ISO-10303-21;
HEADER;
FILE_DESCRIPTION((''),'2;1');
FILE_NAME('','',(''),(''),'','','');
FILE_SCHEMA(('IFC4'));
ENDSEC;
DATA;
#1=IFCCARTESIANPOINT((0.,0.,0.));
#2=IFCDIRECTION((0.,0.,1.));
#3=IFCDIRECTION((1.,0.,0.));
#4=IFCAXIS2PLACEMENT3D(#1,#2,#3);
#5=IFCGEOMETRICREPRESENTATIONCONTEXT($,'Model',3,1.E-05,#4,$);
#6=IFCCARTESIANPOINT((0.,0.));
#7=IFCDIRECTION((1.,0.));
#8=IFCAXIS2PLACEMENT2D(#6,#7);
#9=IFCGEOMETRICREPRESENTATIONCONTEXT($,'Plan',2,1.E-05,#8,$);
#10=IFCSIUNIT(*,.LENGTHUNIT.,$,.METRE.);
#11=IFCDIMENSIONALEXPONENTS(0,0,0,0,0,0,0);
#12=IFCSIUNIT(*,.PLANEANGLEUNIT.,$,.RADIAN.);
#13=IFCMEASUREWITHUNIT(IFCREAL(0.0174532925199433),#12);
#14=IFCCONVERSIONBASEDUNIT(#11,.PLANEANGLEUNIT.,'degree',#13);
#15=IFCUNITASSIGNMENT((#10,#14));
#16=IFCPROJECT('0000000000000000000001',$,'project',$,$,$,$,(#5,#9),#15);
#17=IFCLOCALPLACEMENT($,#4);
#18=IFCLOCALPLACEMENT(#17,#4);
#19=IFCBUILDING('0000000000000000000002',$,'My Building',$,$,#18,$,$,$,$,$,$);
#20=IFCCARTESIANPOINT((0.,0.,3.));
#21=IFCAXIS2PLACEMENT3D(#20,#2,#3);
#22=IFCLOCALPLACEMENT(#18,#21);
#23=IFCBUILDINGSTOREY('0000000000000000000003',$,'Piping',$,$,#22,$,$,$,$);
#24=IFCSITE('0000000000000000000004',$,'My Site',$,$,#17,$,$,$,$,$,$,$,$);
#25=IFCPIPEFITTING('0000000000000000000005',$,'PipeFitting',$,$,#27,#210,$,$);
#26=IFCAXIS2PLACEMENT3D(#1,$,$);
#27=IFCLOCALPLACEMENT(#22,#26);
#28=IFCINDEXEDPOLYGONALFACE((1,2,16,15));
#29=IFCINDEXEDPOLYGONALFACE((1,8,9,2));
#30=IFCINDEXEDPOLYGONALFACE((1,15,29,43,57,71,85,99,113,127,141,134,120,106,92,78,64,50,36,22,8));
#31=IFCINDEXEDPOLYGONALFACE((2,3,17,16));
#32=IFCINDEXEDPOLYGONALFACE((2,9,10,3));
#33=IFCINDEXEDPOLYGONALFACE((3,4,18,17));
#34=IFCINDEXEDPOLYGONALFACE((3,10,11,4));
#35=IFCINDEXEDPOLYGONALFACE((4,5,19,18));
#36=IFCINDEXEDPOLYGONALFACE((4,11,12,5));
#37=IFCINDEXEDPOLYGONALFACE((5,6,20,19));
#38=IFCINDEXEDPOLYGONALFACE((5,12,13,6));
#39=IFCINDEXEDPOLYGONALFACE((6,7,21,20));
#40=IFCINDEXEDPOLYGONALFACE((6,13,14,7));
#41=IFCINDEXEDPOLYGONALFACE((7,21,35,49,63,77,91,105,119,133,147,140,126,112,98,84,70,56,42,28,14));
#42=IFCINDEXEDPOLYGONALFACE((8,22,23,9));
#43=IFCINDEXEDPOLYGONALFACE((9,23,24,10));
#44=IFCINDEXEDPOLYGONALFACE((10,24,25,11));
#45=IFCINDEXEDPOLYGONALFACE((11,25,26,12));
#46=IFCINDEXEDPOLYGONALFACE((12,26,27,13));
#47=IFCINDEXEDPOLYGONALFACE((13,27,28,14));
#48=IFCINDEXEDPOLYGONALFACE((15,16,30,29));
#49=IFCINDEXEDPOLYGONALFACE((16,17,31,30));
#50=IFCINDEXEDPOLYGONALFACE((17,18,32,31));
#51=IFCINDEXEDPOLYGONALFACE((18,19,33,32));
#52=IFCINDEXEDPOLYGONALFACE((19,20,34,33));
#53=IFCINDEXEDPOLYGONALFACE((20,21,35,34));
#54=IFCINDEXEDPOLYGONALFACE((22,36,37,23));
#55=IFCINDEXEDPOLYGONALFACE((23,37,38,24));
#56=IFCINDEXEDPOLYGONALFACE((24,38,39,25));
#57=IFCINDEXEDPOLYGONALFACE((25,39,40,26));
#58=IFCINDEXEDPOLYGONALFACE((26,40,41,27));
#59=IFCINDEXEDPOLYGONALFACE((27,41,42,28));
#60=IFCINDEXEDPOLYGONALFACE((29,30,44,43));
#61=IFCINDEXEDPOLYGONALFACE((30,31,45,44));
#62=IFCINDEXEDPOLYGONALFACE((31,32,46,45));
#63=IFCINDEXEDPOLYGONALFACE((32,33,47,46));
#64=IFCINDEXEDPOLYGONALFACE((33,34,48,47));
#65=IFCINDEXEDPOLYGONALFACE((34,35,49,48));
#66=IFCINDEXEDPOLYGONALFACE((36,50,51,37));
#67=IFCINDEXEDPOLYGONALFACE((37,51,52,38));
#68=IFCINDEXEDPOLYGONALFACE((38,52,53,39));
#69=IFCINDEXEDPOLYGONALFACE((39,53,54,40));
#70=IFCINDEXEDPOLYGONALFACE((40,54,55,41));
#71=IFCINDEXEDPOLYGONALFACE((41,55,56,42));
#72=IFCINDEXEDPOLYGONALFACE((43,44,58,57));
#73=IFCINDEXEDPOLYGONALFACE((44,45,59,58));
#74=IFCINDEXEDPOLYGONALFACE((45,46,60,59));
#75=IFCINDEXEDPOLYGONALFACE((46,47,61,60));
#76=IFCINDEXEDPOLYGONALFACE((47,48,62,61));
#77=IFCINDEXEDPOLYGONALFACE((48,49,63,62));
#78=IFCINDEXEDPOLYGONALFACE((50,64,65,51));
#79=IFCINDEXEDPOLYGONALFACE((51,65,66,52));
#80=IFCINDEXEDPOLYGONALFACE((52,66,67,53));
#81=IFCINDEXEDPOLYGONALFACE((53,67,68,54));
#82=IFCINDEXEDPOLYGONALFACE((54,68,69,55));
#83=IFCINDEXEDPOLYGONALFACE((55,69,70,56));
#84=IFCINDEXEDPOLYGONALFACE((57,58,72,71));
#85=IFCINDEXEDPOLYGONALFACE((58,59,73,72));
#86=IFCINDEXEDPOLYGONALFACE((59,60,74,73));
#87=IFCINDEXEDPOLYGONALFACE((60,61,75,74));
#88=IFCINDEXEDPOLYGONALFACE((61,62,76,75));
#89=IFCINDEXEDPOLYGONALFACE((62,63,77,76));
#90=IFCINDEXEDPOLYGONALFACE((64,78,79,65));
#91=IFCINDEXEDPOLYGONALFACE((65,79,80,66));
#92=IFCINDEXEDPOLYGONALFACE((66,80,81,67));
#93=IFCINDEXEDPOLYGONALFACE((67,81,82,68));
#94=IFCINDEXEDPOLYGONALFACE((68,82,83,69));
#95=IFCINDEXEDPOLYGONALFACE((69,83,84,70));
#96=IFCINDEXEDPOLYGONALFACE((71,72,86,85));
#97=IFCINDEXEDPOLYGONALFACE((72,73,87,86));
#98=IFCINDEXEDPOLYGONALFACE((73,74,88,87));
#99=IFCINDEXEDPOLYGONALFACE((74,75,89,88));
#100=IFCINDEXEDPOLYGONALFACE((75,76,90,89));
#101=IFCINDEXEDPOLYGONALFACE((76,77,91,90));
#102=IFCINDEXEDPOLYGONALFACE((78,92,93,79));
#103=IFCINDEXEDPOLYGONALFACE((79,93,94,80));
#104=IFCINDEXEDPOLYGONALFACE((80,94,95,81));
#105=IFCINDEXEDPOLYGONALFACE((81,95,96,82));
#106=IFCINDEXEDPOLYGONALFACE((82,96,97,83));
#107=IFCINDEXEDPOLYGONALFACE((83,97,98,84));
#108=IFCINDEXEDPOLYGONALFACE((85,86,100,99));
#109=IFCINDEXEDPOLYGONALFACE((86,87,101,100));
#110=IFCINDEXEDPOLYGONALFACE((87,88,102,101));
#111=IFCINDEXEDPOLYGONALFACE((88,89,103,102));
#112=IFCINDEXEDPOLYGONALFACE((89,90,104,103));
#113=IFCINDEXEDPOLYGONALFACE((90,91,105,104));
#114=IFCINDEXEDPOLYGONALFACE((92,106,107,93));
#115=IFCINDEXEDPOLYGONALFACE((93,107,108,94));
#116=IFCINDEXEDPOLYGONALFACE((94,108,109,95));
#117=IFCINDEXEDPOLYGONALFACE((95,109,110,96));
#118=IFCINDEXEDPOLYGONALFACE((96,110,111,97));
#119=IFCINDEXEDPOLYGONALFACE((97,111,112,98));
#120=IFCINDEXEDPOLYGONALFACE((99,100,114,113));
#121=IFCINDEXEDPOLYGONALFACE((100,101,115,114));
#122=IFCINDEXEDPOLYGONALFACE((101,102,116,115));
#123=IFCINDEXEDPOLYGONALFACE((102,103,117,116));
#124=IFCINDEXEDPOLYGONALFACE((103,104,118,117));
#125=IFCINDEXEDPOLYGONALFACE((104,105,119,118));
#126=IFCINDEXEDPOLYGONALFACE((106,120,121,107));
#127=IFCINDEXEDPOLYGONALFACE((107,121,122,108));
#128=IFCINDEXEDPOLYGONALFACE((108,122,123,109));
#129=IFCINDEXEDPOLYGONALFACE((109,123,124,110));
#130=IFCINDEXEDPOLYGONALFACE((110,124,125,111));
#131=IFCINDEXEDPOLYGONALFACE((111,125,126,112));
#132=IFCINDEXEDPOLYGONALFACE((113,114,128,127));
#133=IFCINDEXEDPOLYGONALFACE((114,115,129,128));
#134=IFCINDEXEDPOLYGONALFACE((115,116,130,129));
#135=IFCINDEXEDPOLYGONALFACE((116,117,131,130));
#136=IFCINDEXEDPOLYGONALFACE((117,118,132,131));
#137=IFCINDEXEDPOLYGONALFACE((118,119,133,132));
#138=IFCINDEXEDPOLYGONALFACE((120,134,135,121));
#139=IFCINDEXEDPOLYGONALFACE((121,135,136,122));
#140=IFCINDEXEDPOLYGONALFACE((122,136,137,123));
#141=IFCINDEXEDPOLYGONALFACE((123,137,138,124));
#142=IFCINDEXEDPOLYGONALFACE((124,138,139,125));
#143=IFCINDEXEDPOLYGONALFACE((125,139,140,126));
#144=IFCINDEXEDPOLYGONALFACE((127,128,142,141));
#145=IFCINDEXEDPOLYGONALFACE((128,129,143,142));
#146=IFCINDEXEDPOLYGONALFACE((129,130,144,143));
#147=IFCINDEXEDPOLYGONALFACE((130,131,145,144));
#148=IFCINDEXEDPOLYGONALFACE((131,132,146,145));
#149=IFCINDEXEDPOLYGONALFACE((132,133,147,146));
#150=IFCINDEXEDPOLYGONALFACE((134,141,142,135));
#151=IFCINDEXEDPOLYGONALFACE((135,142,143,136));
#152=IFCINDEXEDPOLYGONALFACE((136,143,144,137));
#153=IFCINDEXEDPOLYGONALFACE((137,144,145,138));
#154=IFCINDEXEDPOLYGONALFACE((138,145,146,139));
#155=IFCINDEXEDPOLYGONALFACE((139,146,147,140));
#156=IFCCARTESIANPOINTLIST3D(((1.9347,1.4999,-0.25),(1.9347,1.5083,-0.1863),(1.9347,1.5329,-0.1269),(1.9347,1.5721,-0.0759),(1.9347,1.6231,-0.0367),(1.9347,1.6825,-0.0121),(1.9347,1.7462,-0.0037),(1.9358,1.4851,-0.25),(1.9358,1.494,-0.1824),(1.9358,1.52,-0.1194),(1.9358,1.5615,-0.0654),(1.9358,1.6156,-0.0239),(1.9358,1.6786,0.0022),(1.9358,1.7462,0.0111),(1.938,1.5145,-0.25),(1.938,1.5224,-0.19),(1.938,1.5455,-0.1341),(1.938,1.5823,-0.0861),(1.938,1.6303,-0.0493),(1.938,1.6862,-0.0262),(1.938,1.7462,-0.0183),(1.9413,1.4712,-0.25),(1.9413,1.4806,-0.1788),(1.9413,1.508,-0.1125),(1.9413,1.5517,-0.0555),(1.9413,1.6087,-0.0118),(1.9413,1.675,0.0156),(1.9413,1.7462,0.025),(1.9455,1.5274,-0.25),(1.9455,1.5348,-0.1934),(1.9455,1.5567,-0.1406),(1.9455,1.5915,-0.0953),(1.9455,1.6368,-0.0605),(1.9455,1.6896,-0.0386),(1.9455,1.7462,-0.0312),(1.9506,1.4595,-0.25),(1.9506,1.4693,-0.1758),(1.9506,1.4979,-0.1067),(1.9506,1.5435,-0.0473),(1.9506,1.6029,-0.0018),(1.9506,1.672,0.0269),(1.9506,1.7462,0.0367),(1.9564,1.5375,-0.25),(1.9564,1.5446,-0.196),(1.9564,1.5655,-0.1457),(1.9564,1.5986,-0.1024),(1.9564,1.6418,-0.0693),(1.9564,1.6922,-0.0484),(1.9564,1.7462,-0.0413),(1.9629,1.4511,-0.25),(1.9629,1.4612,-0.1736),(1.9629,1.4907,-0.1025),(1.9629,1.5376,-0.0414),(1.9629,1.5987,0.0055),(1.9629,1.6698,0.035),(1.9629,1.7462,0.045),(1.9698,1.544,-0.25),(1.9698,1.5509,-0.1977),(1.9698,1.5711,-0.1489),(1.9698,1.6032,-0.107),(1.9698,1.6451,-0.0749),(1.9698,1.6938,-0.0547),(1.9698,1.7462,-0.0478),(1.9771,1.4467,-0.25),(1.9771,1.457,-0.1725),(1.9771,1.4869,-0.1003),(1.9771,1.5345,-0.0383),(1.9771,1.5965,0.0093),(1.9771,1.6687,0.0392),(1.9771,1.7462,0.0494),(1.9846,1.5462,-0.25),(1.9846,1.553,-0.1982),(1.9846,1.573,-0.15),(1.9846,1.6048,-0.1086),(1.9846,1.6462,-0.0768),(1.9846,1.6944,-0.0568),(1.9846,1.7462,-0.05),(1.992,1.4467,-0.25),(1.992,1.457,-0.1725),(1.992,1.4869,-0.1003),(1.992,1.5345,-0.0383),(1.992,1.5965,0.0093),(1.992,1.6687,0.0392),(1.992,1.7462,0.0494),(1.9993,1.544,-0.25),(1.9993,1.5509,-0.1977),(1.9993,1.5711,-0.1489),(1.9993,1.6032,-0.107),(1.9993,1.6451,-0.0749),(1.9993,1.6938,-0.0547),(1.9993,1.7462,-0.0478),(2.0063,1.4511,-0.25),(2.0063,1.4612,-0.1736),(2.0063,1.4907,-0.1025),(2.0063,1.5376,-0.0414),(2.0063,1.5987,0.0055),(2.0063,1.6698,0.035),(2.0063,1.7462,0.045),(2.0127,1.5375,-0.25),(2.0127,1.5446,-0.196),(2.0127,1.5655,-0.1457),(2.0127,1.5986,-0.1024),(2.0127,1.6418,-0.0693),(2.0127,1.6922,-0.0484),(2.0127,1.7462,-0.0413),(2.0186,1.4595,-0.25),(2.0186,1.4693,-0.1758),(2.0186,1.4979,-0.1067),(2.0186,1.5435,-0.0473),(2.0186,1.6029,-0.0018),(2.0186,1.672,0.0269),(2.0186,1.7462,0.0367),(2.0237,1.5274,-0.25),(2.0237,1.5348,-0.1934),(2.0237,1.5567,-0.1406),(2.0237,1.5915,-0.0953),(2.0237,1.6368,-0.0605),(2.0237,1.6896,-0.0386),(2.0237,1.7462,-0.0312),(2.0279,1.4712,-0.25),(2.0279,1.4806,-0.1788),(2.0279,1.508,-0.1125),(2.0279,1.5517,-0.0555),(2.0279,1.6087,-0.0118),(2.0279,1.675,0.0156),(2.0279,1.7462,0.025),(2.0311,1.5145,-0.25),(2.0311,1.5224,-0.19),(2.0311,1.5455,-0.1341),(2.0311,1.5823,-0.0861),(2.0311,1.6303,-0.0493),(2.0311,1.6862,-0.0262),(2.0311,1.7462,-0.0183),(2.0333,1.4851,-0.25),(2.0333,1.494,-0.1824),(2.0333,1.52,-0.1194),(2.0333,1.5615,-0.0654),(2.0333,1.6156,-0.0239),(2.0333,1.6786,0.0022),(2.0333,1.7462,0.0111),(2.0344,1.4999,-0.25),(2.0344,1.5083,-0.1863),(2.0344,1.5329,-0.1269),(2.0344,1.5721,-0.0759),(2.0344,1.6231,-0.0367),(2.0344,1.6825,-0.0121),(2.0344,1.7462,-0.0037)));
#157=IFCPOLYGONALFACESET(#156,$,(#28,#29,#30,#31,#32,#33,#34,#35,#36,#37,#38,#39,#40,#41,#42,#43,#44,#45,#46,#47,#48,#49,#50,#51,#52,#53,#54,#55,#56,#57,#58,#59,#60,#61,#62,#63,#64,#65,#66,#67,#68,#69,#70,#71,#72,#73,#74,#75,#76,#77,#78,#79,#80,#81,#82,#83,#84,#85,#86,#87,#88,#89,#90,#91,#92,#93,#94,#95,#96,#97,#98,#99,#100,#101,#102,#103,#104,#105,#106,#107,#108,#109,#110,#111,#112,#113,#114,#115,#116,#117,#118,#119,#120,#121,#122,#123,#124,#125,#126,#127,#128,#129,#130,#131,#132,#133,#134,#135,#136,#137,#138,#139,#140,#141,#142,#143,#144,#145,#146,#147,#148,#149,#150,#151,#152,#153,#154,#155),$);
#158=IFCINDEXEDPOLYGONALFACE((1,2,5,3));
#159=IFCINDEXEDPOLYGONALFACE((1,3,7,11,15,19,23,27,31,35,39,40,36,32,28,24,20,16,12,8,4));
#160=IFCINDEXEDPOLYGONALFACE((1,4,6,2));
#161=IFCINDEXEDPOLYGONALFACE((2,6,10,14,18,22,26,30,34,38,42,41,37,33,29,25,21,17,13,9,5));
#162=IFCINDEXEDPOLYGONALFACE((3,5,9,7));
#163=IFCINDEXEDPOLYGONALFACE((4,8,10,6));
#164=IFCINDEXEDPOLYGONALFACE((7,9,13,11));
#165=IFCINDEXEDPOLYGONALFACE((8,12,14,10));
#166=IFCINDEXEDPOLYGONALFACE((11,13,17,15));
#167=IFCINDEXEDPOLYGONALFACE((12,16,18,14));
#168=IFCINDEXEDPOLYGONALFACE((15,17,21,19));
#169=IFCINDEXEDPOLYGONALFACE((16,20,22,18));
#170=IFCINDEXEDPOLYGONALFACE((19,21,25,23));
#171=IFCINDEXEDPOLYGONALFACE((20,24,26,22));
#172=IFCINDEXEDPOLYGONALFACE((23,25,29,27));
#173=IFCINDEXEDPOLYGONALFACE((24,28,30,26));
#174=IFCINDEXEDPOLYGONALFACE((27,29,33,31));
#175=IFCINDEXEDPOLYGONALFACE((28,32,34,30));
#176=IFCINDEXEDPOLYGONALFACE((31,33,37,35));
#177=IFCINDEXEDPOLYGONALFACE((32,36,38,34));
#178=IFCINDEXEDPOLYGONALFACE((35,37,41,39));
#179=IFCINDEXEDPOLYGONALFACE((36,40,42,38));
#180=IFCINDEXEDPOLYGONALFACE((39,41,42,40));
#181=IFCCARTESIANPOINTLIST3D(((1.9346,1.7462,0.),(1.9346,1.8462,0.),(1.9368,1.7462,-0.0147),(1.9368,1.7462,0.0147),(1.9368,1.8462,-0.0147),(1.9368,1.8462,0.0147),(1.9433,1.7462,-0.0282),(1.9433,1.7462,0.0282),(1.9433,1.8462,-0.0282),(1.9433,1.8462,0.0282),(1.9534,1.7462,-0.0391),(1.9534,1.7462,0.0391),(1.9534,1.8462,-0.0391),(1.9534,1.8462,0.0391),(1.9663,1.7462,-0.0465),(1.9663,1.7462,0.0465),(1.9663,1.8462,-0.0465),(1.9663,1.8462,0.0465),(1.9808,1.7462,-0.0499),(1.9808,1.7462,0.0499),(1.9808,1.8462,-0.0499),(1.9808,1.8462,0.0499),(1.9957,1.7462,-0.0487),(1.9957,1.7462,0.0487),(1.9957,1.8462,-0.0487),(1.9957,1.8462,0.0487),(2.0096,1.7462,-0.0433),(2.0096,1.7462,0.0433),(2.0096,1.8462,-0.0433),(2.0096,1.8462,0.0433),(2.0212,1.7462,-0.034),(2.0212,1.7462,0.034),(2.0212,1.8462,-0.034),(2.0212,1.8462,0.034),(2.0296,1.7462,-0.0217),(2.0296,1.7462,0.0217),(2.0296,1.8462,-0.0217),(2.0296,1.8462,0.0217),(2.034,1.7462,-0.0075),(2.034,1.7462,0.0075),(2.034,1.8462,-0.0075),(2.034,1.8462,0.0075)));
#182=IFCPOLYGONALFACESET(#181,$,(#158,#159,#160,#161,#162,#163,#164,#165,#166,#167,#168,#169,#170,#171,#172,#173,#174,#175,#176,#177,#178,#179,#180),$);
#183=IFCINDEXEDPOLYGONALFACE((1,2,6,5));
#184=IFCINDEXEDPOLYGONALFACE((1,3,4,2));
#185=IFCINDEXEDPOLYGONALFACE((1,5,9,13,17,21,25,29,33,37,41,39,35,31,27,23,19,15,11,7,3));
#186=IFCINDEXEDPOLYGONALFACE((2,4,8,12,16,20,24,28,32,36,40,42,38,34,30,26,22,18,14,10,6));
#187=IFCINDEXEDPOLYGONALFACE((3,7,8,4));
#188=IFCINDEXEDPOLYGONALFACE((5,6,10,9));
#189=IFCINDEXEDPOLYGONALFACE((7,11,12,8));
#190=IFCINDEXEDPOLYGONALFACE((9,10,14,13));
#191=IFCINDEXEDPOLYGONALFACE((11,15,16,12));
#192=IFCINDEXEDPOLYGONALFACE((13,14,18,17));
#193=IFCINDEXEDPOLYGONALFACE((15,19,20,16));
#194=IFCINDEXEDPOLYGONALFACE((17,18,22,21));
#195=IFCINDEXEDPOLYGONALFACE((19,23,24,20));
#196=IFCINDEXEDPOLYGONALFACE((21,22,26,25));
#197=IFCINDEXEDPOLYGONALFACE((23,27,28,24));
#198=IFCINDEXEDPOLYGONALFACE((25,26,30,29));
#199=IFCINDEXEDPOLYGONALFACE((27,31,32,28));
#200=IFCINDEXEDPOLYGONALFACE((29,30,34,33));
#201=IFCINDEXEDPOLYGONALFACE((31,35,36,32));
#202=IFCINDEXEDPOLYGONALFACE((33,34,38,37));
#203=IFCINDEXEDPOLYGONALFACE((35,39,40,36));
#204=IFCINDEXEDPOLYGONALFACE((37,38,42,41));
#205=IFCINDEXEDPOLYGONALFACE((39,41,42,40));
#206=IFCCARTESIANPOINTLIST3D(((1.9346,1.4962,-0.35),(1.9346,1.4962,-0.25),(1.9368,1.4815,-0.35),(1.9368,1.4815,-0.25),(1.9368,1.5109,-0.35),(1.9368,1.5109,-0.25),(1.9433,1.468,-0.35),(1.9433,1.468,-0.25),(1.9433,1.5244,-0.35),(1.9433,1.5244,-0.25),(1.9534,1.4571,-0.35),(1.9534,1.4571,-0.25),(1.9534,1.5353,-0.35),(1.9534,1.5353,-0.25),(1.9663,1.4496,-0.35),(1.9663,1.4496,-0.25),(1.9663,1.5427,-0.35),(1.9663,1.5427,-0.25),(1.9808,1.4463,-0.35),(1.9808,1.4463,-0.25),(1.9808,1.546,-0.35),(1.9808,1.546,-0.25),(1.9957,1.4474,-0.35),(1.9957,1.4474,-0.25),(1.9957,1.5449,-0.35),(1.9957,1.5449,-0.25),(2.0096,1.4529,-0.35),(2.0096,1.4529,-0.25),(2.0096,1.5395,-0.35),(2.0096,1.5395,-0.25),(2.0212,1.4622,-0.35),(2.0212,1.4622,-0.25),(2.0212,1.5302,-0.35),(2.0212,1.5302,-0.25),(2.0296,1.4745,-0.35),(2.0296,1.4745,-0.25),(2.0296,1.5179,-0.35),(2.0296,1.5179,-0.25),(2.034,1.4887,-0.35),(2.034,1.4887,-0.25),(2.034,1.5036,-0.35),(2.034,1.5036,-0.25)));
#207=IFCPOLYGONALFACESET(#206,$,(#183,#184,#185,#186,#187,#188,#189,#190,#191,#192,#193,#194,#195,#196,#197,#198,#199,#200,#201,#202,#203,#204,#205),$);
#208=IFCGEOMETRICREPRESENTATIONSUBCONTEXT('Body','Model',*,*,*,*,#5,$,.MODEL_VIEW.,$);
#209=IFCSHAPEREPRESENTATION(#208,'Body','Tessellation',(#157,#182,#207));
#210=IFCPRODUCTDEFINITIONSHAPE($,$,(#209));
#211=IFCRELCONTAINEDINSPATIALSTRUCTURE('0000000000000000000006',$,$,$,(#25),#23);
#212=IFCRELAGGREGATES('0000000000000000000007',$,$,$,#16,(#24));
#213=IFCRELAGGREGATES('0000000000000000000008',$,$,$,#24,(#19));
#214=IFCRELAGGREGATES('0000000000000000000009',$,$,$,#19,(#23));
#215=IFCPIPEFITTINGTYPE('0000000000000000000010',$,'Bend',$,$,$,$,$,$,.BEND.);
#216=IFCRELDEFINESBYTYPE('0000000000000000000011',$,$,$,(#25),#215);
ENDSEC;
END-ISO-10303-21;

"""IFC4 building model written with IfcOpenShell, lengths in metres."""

from ifc_helpers import new_model, entity, si_unit, converted_unit, frame, origin_with_axes, origin_2d_with_axis, place, context, subcontext, project, spatial, circle, extrude, source, transform, mapped, type_object, type_shapes, element, save


model = new_model("IFC4")

# Units and contexts
model_context = context("Model", 3, precision=1e-05, world=origin_with_axes())
plan_context = context("Plan", 2, precision=1e-05, world=origin_2d_with_axis())
body_context = subcontext(model_context, "Body", "Model", "MODEL_VIEW")
ifc_project = project(units=[si_unit("LENGTHUNIT", "METRE"), converted_unit("PLANEANGLEUNIT", "degree", entity("IfcReal", 0.0174532925199433), si_unit("PLANEANGLEUNIT", "RADIAN"), dimensions=[0, 0, 0, 0, 0, 0, 0])], contexts=[model_context, plan_context])

# Site, building, storey
site_placement = place(None, origin_with_axes())
site = spatial("IfcSite", under=ifc_project, at=site_placement, Name="My Site")
building_placement = place(site_placement, origin_with_axes())
building = spatial("IfcBuilding", under=site, at=building_placement, Name="My Building")
storey_placement = place(building_placement, frame((0.0, 0.0, 3.0), z_axis=(0.0, 0.0, 1.0), x_axis=(1.0, 0.0, 0.0)))
storey = spatial("IfcBuildingStorey", under=building, at=storey_placement, Name="Piping")

# Pipe fitting
pipe_fitting_type = type_object("IfcPipeFittingType", Name="Bend", PredefinedType="BEND")
shared_shape = source(origin_with_axes(), body_context, "Body", "SolidModel", [
    entity("IfcSweptDiskSolid", entity("IfcIndexedPolyCurve", entity("IfcCartesianPointList3D", [[0.0, 0.0, -0.1], [0.0, -0.0732, -0.2768], [0.0, -0.25, -0.35]]), [entity("IfcArcIndex", [1, 2, 3])]), 0.05),
    extrude(circle(Radius=0.05), origin_with_axes(), (0.0, 0.0, -1.0), 0.1),
    extrude(circle(Radius=0.05), frame((0.0, -0.25, -0.35), z_axis=(0.0, -1.0, 0.0), x_axis=(1.0, 0.0, 0.0)), (0.0, 0.0, 1.0), 0.1),
])
type_shapes(pipe_fitting_type, [shared_shape])
pipe_fitting_placement = place(storey_placement, frame((1.9846, 1.8462, 0.0), z_axis=(0.0, 1.0, 0.0), x_axis=(-1.0, 0.0, 0.0)))
element("IfcPipeFitting", 1, at=pipe_fitting_placement, inside=storey, type_object=pipe_fitting_type, Name="PipeFitting", context=body_context, shape_type="MappedRepresentation", body=[
    mapped(shared_shape, transform((0.0, 0.0, 0.0), x_axis=(1.0, 0.0, 0.0), y_axis=(0.0, 1.0, 0.0), z_axis=(0.0, 0.0, 1.0), scale=1.0)),
])

save(model, "model.ifc")
